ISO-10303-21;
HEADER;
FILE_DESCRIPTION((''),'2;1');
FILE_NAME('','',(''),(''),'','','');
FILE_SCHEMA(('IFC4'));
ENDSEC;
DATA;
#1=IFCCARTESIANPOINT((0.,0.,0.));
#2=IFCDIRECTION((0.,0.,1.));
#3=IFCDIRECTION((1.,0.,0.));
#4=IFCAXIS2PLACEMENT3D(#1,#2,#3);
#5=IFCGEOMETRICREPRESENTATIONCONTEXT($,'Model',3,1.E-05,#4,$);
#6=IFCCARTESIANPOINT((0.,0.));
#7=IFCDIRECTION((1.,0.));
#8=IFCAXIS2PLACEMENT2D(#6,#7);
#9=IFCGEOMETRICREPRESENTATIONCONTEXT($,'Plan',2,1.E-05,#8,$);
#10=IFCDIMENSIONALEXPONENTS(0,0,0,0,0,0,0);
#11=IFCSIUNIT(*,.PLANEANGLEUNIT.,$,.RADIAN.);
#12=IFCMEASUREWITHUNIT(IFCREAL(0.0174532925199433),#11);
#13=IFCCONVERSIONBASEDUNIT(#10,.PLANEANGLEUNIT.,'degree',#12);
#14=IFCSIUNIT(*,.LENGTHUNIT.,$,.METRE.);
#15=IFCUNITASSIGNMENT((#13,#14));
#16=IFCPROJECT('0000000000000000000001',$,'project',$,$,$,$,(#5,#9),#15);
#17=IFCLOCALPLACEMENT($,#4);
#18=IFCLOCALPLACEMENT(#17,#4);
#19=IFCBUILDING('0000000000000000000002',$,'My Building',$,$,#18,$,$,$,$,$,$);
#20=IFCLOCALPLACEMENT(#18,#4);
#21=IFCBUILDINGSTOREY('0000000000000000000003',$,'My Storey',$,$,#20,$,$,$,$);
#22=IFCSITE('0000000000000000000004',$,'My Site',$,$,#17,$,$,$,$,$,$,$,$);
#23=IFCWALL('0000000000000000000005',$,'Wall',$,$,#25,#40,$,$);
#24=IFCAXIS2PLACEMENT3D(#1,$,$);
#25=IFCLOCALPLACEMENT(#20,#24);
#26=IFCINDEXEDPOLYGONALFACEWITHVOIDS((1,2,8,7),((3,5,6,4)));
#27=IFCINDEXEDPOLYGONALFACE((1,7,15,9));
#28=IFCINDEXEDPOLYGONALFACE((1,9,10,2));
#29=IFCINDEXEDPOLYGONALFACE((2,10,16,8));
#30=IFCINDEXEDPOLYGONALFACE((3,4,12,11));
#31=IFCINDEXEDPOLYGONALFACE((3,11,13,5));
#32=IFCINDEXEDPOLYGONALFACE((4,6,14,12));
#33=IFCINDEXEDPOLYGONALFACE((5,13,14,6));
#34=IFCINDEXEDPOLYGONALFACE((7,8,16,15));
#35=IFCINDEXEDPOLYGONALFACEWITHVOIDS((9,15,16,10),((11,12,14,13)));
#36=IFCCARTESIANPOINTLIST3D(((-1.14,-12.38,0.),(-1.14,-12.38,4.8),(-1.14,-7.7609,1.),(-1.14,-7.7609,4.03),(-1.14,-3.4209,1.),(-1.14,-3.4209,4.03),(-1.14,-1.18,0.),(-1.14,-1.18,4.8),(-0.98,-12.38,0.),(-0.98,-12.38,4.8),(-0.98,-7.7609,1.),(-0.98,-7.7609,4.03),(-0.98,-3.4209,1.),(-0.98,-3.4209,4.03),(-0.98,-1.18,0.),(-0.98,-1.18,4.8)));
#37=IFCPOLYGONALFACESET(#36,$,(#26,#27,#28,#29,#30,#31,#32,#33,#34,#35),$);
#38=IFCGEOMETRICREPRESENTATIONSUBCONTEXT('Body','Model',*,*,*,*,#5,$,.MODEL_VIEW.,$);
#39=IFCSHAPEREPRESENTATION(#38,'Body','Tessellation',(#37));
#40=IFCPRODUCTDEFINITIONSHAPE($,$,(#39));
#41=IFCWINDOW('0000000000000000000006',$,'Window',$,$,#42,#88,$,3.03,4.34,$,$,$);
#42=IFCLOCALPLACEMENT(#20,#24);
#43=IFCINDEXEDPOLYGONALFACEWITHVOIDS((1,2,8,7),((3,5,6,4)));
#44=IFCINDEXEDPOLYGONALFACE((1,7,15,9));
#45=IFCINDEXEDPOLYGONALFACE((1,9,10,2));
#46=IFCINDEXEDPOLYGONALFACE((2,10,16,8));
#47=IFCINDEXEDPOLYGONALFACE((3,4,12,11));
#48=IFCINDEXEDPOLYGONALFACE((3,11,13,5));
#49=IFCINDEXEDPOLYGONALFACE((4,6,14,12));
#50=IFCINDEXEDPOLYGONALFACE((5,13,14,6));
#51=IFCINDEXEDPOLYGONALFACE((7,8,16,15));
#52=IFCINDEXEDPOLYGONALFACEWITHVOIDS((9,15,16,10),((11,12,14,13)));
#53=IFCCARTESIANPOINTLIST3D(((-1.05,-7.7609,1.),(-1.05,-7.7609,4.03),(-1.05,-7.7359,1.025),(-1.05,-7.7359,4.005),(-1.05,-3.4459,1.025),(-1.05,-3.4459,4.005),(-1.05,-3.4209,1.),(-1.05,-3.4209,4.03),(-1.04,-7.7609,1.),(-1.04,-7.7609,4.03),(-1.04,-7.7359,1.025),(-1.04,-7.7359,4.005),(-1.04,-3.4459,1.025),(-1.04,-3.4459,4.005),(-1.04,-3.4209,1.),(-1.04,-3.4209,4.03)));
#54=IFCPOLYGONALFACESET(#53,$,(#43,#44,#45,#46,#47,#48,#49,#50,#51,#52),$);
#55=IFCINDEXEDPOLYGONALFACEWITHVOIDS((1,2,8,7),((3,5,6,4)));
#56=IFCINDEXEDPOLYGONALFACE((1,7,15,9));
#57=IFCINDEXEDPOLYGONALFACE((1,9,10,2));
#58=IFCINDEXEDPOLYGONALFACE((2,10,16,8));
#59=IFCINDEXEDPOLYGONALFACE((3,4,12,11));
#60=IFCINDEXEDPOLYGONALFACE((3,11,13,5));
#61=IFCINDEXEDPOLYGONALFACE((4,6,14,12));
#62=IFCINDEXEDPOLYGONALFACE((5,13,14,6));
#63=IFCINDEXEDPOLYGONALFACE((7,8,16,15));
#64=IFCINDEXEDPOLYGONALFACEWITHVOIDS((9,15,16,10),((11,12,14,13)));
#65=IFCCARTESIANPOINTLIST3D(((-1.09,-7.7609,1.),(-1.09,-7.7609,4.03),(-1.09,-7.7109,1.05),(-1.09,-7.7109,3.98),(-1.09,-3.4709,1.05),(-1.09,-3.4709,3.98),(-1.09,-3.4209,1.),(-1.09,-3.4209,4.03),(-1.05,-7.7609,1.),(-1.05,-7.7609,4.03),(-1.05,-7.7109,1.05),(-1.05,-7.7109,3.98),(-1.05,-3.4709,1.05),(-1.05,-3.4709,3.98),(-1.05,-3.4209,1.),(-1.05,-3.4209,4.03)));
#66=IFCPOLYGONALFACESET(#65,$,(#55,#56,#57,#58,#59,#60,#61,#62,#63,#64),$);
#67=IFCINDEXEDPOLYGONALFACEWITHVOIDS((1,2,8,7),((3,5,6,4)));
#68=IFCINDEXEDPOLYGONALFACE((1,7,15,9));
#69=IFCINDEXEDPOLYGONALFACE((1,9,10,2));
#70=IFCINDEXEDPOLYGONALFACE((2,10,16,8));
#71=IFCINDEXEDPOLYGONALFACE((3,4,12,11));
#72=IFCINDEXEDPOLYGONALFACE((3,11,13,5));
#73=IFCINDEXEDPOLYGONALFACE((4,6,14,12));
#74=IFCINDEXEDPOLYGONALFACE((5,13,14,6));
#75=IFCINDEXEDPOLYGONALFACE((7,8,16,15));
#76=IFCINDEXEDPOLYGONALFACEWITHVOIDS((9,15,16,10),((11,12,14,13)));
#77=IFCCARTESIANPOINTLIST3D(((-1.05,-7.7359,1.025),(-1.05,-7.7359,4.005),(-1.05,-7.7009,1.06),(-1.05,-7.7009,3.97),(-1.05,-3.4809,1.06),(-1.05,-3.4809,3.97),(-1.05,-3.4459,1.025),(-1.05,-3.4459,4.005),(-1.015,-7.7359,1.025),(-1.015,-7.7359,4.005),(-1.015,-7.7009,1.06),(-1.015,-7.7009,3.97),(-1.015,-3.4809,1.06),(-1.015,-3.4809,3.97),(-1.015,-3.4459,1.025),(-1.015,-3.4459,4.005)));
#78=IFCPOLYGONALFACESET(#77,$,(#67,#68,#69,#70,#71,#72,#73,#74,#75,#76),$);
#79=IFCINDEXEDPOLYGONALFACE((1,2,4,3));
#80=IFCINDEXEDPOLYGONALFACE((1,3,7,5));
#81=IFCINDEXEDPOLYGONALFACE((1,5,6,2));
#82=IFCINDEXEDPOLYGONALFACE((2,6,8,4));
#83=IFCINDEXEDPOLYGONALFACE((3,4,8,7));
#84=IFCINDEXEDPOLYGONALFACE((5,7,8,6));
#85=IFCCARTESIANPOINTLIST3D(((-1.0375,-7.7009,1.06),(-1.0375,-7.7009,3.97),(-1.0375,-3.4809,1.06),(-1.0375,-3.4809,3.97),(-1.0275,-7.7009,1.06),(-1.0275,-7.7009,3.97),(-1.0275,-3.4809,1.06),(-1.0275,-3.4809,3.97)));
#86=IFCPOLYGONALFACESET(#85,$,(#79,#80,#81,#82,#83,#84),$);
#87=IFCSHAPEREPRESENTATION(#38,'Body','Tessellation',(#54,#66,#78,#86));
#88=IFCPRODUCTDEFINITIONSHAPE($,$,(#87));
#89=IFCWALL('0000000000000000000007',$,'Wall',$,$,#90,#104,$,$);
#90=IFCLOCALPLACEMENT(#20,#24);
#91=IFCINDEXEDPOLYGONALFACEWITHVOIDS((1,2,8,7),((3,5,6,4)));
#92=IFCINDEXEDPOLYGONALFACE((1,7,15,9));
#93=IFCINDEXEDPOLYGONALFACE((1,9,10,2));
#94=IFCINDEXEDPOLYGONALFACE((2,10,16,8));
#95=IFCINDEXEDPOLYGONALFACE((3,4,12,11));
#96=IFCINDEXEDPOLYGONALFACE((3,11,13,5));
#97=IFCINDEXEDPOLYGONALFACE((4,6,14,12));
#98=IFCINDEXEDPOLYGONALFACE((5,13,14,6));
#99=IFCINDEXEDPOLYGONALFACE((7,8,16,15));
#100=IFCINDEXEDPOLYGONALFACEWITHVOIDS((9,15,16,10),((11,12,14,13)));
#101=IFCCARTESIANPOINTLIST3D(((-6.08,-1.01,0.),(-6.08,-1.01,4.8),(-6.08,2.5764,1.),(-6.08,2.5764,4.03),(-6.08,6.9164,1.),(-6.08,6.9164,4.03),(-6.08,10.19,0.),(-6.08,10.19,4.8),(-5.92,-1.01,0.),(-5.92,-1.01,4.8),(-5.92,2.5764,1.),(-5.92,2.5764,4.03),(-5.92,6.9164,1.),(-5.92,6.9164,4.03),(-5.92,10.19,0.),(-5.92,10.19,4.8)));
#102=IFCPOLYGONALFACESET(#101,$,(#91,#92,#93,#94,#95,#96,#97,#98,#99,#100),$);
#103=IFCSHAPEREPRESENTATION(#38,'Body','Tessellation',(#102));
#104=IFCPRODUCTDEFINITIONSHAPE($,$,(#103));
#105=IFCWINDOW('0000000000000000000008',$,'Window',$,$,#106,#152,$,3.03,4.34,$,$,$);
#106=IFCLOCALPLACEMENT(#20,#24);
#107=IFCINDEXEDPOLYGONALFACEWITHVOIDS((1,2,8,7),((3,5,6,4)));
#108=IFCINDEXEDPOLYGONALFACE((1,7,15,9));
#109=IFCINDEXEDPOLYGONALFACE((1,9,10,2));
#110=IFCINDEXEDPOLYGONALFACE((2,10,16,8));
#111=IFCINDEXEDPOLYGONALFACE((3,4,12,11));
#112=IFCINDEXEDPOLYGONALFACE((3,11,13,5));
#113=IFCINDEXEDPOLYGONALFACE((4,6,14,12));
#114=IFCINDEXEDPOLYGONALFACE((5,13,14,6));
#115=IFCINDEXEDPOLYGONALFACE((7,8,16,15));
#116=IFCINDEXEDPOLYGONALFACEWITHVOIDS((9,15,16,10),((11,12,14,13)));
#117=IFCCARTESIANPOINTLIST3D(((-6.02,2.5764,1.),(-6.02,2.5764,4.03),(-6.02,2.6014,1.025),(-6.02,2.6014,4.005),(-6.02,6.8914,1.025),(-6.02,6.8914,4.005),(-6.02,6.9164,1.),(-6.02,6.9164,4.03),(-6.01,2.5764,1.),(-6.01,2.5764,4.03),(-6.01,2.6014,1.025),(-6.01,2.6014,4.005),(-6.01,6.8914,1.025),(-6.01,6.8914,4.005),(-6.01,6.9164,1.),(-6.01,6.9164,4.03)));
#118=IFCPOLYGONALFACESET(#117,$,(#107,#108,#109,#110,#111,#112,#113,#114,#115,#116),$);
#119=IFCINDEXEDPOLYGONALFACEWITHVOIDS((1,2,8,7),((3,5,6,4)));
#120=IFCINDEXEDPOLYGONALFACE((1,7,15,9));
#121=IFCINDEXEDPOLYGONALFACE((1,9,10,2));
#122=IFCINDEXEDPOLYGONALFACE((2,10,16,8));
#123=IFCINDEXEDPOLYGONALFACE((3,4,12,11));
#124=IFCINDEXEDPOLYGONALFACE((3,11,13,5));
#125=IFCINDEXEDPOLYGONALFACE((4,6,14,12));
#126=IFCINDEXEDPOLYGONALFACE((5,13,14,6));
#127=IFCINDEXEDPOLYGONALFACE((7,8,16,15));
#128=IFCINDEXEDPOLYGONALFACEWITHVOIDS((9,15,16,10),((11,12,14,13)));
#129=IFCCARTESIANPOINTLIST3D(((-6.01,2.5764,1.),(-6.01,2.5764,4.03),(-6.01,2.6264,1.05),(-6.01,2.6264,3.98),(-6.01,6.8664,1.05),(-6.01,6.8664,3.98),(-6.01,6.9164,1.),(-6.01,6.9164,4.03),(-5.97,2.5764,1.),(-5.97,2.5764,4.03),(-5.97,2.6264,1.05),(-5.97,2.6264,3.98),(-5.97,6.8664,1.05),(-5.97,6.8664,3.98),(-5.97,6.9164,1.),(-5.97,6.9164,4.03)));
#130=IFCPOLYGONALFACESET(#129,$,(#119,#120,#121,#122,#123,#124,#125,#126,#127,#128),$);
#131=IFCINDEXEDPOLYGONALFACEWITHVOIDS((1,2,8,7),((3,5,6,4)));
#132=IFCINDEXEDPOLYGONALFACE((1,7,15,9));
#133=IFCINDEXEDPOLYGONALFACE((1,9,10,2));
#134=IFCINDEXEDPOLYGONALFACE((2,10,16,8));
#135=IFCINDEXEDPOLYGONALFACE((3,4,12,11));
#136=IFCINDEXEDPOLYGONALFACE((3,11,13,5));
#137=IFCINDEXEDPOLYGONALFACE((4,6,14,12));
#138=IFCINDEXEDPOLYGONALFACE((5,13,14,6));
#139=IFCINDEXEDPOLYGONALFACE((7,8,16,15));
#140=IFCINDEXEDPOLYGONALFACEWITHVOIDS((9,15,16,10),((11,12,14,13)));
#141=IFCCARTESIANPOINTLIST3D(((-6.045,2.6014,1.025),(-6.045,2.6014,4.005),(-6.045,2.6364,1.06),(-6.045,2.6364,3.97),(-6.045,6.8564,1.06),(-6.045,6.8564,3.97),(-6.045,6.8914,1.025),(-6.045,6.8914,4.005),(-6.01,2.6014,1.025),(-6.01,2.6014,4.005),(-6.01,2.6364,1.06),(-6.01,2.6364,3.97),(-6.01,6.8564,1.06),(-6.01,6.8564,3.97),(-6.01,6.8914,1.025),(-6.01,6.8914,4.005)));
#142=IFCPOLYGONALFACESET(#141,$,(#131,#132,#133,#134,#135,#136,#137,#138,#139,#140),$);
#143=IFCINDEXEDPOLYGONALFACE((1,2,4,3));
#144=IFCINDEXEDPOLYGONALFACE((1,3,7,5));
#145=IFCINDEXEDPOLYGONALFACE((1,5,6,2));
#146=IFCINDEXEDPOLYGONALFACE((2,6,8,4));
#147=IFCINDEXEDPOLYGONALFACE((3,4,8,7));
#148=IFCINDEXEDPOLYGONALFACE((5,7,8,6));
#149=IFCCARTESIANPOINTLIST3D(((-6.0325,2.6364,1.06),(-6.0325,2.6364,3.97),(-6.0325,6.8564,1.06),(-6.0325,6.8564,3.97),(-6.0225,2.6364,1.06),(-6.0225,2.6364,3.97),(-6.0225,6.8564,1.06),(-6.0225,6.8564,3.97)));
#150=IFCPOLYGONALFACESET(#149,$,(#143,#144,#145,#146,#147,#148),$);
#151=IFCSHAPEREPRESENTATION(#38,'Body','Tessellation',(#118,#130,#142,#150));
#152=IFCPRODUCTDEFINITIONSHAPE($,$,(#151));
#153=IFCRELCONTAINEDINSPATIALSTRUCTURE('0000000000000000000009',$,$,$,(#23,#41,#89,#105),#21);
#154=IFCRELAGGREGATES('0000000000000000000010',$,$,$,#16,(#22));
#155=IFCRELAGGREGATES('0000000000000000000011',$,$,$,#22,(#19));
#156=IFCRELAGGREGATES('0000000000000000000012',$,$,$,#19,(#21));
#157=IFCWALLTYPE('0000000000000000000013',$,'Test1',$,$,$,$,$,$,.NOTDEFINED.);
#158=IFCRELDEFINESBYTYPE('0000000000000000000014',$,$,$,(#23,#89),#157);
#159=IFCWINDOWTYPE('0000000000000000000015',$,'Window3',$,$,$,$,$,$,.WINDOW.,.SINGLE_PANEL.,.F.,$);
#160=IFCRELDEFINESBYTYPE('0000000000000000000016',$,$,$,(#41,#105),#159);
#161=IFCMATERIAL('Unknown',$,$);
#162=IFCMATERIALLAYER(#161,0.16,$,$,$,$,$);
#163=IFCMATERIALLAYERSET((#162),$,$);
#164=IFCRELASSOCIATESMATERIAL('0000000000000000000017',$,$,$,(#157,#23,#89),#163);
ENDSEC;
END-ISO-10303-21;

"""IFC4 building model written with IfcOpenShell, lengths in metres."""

from ifc_helpers import new_model, entity, si_unit, converted_unit, frame, origin_with_axes, origin_2d_with_axis, place, context, subcontext, project, spatial, line, indexed_curve, outline, extrude, shape, source, transform, mapped, material, layer, layer_set, layer_usage, type_object, type_shapes, element, fill, save


model = new_model("IFC4")

# Units and contexts
model_context = context("Model", 3, precision=1e-05, world=origin_with_axes())
plan_context = context("Plan", 2, precision=1e-05, world=origin_2d_with_axis())
body_context_1 = subcontext(model_context, "Body", "Model", "MODEL_VIEW")
body_context_2 = subcontext(plan_context, "Body", "Plan", "PLAN_VIEW")
ifc_project = project(units=[converted_unit("PLANEANGLEUNIT", "degree", entity("IfcReal", 0.0174532925199433), si_unit("PLANEANGLEUNIT", "RADIAN"), dimensions=[0, 0, 0, 0, 0, 0, 0]), si_unit("LENGTHUNIT", "METRE")], contexts=[model_context, plan_context])

# Site, building, storey
site_placement = place(None, origin_with_axes())
site = spatial("IfcSite", under=ifc_project, at=site_placement, Name="My Site")
building_placement = place(site_placement, origin_with_axes())
building = spatial("IfcBuilding", under=site, at=building_placement, Name="My Building")
storey_placement = place(building_placement, origin_with_axes())
storey = spatial("IfcBuildingStorey", under=building, at=storey_placement, Name="My Storey")

# Shared definitions
ifc_material = material(Name="Unknown")
ifc_layer = layer(ifc_material, 0.16)
ifc_layer_set = layer_set([ifc_layer])
wall_type = type_object("IfcWallType", Name="Test1", PredefinedType="NOTDEFINED", material=ifc_layer_set)
shared_shape_1 = source(origin_with_axes(), body_context_1, "Body", "SweptSolid", [
    extrude(outline(indexed_curve([(0.0, 0.0), (4.34, 0.0), (4.34, 3.03), (0.0, 3.03)], segments=[line(1, 2, 3, 4, 1)])), frame((0.0, -0.1, 0.0), z_axis=(0.0, -1.0, 0.0), x_axis=(1.0, 0.0, 0.0)), (0.0, 0.0, -1.0), 0.36),
])
window_type = type_object("IfcWindowType", Name="Window3", ParameterTakesPrecedence=False, PartitioningType="SINGLE_PANEL", PredefinedType="WINDOW")
shared_shape_2 = source(origin_with_axes(), body_context_1, "Body", "SweptSolid", [
    extrude(outline(indexed_curve([(0.0, 0.0), (4.34, 0.0), (4.34, 3.03), (0.0, 3.03)], segments=[line(1, 2, 3, 4, 1)]), holes=[indexed_curve([(0.025, 0.025), (4.315, 0.025), (4.315, 3.005), (0.025, 3.005)], segments=[line(1, 2, 3, 4, 1)])]), frame((0.0, 0.09, 0.0), z_axis=(0.0, -1.0, 0.0), x_axis=(1.0, 0.0, 0.0)), (0.0, 0.0, -1.0), 0.01),
    extrude(outline(indexed_curve([(0.0, 0.0), (4.34, 0.0), (4.34, 3.03), (0.0, 3.03)], segments=[line(1, 2, 3, 4, 1)]), holes=[indexed_curve([(0.05, 0.05), (4.29, 0.05), (4.29, 2.98), (0.05, 2.98)], segments=[line(1, 2, 3, 4, 1)])]), frame((0.0, 0.05, 0.0), z_axis=(0.0, -1.0, 0.0), x_axis=(1.0, 0.0, 0.0)), (0.0, 0.0, -1.0), 0.04),
    extrude(outline(indexed_curve([(0.0, 0.0), (4.29, 0.0), (4.29, 2.98), (0.0, 2.98)], segments=[line(1, 2, 3, 4, 1)]), holes=[indexed_curve([(0.035, 0.035), (4.255, 0.035), (4.255, 2.945), (0.035, 2.945)], segments=[line(1, 2, 3, 4, 1)])]), frame((0.025, 0.09, 0.025), z_axis=(0.0, -1.0, 0.0), x_axis=(1.0, 0.0, 0.0)), (0.0, 0.0, -1.0), 0.035),
    extrude(outline(indexed_curve([(0.035, 0.035), (4.255, 0.035), (4.255, 2.945), (0.035, 2.945)], segments=[line(1, 2, 3, 4, 1)])), frame((0.025, 0.1025, 0.025), z_axis=(0.0, -1.0, 0.0), x_axis=(1.0, 0.0, 0.0)), (0.0, 0.0, -1.0), 0.01),
])
shared_shape_3 = source(origin_with_axes(), body_context_2, "Body", "Curve2D", [
    entity("IfcIndexedPolyCurve", entity("IfcCartesianPointList2D", [[0.05, 0.05], [4.29, 0.05]])),
    entity("IfcIndexedPolyCurve", entity("IfcCartesianPointList2D", [[0.0, 0.1], [0.025, 0.1], [0.025, 0.09], [0.05, 0.09], [0.05, 0.05], [0.0, 0.05]]), [entity("IfcLineIndex", [1, 2, 3, 4, 5, 6, 1])]),
    entity("IfcIndexedPolyCurve", entity("IfcCartesianPointList2D", [[4.34, 0.1], [4.315, 0.1], [4.315, 0.09], [4.29, 0.09], [4.29, 0.05], [4.34, 0.05]]), [entity("IfcLineIndex", [1, 2, 3, 4, 5, 6, 1])]),
    entity("IfcIndexedPolyCurve", entity("IfcCartesianPointList2D", [[0.025, 0.09], [0.06, 0.09], [0.06, 0.125], [0.025, 0.125]]), [entity("IfcLineIndex", [1, 2, 3, 4, 1])]),
    entity("IfcIndexedPolyCurve", entity("IfcCartesianPointList2D", [[4.315, 0.09], [4.28, 0.09], [4.28, 0.125], [4.315, 0.125]]), [entity("IfcLineIndex", [1, 2, 3, 4, 1])]),
    entity("IfcIndexedPolyCurve", entity("IfcCartesianPointList2D", [[0.06, 0.09], [4.28, 0.09]])),
    entity("IfcIndexedPolyCurve", entity("IfcCartesianPointList2D", [[0.06, 0.125], [4.28, 0.125]])),
    entity("IfcIndexedPolyCurve", entity("IfcCartesianPointList2D", [[0.06, 0.1075], [4.28, 0.1075]])),
])
type_shapes(window_type, [shared_shape_2, shared_shape_3])

# Walls, openings, windows
ifc_layer_usage_1 = layer_usage(ifc_layer_set, "AXIS2", "POSITIVE", 0.0)
wall_1_placement = place(storey_placement, frame((-1.14, -1.18, 0.0), z_axis=(0.0, 0.0, 1.0), x_axis=(0.0, -1.0, 0.0)))
wall_1 = element("IfcWall", 1, at=wall_1_placement, inside=storey, type_object=wall_type, material=ifc_layer_usage_1, Name="Wall", context=body_context_1, shape_type="SweptSolid", body=[
    extrude(outline(indexed_curve([(0.0, 0.0), (0.0, 0.16), (11.2, 0.16), (11.2, 0.0), (0.0, 0.0)], self_intersect=False)), origin_with_axes(), (0.0, 0.0, 1.0), 4.8),
])
opening_1_placement = place(wall_1_placement, frame((2.2409, 0.0, 1.0), z_axis=(0.0, 0.0, 1.0), x_axis=(1.0, 0.0, 0.0)))
opening_1 = element("IfcOpeningElement", 2, at=opening_1_placement, cuts=wall_1, PredefinedType="OPENING", context=body_context_1, shape_type="MappedRepresentation", body=[
    mapped(shared_shape_1, transform((0.0, 0.0, 0.0), x_axis=(1.0, 0.0, 0.0), y_axis=(0.0, 1.0, 0.0), z_axis=(0.0, 0.0, 1.0), scale=1.0)),
])
window_1_placement = place(opening_1_placement, frame((0.0, 0.0, 0.0), z_axis=(0.0, 0.0, 1.0), x_axis=(1.0, 0.0, 0.0)))
window_1 = element("IfcWindow", 3, at=window_1_placement, inside=storey, type_object=window_type, Name="Window", OverallHeight=3.03, OverallWidth=4.34, shapes=[
    shape(body_context_1, "Body", "MappedRepresentation", [mapped(shared_shape_2, transform((0.0, 0.0, 0.0), x_axis=(1.0, 0.0, 0.0), y_axis=(0.0, 1.0, 0.0), z_axis=(0.0, 0.0, 1.0), scale=1.0))]),
    shape(body_context_2, "Body", "MappedRepresentation", [mapped(shared_shape_3, transform((0.0, 0.0, 0.0), x_axis=(1.0, 0.0, 0.0), y_axis=(0.0, 1.0, 0.0), z_axis=(0.0, 0.0, 1.0), scale=1.0))]),
])
fill(opening_1, window_1)
ifc_layer_usage_2 = layer_usage(ifc_layer_set, "AXIS2", "POSITIVE", 0.0)
wall_2_placement = place(storey_placement, frame((-5.92, -1.01, 0.0), z_axis=(0.0, 0.0, 1.0), x_axis=(0.0, 1.0, 0.0)))
wall_2 = element("IfcWall", 4, at=wall_2_placement, inside=storey, type_object=wall_type, material=ifc_layer_usage_2, Name="Wall", context=body_context_1, shape_type="SweptSolid", body=[
    extrude(outline(indexed_curve([(0.0, 0.0), (0.0, 0.16), (11.2, 0.16), (11.2, 0.0), (0.0, 0.0)], self_intersect=False)), origin_with_axes(), (0.0, 0.0, 1.0), 4.8),
])
opening_2_placement = place(wall_2_placement, frame((3.5864, 0.0, 1.0), z_axis=(0.0, 0.0, 1.0), x_axis=(1.0, 0.0, 0.0)))
opening_2 = element("IfcOpeningElement", 5, at=opening_2_placement, cuts=wall_2, PredefinedType="OPENING", context=body_context_1, shape_type="MappedRepresentation", body=[
    mapped(shared_shape_1, transform((0.0, 0.0, 0.0), x_axis=(1.0, 0.0, 0.0), y_axis=(0.0, 1.0, 0.0), z_axis=(0.0, 0.0, 1.0), scale=1.0)),
])
window_2_placement = place(opening_2_placement, frame((0.0, 0.0, 0.0), z_axis=(0.0, 0.0, 1.0), x_axis=(1.0, 0.0, 0.0)))
window_2 = element("IfcWindow", 6, at=window_2_placement, inside=storey, type_object=window_type, Name="Window", OverallHeight=3.03, OverallWidth=4.34, shapes=[
    shape(body_context_1, "Body", "MappedRepresentation", [mapped(shared_shape_2, transform((0.0, 0.0, 0.0), x_axis=(1.0, 0.0, 0.0), y_axis=(0.0, 1.0, 0.0), z_axis=(0.0, 0.0, 1.0), scale=1.0))]),
    shape(body_context_2, "Body", "MappedRepresentation", [mapped(shared_shape_3, transform((0.0, 0.0, 0.0), x_axis=(1.0, 0.0, 0.0), y_axis=(0.0, 1.0, 0.0), z_axis=(0.0, 0.0, 1.0), scale=1.0))]),
])
fill(opening_2, window_2)

save(model, "model.ifc")
